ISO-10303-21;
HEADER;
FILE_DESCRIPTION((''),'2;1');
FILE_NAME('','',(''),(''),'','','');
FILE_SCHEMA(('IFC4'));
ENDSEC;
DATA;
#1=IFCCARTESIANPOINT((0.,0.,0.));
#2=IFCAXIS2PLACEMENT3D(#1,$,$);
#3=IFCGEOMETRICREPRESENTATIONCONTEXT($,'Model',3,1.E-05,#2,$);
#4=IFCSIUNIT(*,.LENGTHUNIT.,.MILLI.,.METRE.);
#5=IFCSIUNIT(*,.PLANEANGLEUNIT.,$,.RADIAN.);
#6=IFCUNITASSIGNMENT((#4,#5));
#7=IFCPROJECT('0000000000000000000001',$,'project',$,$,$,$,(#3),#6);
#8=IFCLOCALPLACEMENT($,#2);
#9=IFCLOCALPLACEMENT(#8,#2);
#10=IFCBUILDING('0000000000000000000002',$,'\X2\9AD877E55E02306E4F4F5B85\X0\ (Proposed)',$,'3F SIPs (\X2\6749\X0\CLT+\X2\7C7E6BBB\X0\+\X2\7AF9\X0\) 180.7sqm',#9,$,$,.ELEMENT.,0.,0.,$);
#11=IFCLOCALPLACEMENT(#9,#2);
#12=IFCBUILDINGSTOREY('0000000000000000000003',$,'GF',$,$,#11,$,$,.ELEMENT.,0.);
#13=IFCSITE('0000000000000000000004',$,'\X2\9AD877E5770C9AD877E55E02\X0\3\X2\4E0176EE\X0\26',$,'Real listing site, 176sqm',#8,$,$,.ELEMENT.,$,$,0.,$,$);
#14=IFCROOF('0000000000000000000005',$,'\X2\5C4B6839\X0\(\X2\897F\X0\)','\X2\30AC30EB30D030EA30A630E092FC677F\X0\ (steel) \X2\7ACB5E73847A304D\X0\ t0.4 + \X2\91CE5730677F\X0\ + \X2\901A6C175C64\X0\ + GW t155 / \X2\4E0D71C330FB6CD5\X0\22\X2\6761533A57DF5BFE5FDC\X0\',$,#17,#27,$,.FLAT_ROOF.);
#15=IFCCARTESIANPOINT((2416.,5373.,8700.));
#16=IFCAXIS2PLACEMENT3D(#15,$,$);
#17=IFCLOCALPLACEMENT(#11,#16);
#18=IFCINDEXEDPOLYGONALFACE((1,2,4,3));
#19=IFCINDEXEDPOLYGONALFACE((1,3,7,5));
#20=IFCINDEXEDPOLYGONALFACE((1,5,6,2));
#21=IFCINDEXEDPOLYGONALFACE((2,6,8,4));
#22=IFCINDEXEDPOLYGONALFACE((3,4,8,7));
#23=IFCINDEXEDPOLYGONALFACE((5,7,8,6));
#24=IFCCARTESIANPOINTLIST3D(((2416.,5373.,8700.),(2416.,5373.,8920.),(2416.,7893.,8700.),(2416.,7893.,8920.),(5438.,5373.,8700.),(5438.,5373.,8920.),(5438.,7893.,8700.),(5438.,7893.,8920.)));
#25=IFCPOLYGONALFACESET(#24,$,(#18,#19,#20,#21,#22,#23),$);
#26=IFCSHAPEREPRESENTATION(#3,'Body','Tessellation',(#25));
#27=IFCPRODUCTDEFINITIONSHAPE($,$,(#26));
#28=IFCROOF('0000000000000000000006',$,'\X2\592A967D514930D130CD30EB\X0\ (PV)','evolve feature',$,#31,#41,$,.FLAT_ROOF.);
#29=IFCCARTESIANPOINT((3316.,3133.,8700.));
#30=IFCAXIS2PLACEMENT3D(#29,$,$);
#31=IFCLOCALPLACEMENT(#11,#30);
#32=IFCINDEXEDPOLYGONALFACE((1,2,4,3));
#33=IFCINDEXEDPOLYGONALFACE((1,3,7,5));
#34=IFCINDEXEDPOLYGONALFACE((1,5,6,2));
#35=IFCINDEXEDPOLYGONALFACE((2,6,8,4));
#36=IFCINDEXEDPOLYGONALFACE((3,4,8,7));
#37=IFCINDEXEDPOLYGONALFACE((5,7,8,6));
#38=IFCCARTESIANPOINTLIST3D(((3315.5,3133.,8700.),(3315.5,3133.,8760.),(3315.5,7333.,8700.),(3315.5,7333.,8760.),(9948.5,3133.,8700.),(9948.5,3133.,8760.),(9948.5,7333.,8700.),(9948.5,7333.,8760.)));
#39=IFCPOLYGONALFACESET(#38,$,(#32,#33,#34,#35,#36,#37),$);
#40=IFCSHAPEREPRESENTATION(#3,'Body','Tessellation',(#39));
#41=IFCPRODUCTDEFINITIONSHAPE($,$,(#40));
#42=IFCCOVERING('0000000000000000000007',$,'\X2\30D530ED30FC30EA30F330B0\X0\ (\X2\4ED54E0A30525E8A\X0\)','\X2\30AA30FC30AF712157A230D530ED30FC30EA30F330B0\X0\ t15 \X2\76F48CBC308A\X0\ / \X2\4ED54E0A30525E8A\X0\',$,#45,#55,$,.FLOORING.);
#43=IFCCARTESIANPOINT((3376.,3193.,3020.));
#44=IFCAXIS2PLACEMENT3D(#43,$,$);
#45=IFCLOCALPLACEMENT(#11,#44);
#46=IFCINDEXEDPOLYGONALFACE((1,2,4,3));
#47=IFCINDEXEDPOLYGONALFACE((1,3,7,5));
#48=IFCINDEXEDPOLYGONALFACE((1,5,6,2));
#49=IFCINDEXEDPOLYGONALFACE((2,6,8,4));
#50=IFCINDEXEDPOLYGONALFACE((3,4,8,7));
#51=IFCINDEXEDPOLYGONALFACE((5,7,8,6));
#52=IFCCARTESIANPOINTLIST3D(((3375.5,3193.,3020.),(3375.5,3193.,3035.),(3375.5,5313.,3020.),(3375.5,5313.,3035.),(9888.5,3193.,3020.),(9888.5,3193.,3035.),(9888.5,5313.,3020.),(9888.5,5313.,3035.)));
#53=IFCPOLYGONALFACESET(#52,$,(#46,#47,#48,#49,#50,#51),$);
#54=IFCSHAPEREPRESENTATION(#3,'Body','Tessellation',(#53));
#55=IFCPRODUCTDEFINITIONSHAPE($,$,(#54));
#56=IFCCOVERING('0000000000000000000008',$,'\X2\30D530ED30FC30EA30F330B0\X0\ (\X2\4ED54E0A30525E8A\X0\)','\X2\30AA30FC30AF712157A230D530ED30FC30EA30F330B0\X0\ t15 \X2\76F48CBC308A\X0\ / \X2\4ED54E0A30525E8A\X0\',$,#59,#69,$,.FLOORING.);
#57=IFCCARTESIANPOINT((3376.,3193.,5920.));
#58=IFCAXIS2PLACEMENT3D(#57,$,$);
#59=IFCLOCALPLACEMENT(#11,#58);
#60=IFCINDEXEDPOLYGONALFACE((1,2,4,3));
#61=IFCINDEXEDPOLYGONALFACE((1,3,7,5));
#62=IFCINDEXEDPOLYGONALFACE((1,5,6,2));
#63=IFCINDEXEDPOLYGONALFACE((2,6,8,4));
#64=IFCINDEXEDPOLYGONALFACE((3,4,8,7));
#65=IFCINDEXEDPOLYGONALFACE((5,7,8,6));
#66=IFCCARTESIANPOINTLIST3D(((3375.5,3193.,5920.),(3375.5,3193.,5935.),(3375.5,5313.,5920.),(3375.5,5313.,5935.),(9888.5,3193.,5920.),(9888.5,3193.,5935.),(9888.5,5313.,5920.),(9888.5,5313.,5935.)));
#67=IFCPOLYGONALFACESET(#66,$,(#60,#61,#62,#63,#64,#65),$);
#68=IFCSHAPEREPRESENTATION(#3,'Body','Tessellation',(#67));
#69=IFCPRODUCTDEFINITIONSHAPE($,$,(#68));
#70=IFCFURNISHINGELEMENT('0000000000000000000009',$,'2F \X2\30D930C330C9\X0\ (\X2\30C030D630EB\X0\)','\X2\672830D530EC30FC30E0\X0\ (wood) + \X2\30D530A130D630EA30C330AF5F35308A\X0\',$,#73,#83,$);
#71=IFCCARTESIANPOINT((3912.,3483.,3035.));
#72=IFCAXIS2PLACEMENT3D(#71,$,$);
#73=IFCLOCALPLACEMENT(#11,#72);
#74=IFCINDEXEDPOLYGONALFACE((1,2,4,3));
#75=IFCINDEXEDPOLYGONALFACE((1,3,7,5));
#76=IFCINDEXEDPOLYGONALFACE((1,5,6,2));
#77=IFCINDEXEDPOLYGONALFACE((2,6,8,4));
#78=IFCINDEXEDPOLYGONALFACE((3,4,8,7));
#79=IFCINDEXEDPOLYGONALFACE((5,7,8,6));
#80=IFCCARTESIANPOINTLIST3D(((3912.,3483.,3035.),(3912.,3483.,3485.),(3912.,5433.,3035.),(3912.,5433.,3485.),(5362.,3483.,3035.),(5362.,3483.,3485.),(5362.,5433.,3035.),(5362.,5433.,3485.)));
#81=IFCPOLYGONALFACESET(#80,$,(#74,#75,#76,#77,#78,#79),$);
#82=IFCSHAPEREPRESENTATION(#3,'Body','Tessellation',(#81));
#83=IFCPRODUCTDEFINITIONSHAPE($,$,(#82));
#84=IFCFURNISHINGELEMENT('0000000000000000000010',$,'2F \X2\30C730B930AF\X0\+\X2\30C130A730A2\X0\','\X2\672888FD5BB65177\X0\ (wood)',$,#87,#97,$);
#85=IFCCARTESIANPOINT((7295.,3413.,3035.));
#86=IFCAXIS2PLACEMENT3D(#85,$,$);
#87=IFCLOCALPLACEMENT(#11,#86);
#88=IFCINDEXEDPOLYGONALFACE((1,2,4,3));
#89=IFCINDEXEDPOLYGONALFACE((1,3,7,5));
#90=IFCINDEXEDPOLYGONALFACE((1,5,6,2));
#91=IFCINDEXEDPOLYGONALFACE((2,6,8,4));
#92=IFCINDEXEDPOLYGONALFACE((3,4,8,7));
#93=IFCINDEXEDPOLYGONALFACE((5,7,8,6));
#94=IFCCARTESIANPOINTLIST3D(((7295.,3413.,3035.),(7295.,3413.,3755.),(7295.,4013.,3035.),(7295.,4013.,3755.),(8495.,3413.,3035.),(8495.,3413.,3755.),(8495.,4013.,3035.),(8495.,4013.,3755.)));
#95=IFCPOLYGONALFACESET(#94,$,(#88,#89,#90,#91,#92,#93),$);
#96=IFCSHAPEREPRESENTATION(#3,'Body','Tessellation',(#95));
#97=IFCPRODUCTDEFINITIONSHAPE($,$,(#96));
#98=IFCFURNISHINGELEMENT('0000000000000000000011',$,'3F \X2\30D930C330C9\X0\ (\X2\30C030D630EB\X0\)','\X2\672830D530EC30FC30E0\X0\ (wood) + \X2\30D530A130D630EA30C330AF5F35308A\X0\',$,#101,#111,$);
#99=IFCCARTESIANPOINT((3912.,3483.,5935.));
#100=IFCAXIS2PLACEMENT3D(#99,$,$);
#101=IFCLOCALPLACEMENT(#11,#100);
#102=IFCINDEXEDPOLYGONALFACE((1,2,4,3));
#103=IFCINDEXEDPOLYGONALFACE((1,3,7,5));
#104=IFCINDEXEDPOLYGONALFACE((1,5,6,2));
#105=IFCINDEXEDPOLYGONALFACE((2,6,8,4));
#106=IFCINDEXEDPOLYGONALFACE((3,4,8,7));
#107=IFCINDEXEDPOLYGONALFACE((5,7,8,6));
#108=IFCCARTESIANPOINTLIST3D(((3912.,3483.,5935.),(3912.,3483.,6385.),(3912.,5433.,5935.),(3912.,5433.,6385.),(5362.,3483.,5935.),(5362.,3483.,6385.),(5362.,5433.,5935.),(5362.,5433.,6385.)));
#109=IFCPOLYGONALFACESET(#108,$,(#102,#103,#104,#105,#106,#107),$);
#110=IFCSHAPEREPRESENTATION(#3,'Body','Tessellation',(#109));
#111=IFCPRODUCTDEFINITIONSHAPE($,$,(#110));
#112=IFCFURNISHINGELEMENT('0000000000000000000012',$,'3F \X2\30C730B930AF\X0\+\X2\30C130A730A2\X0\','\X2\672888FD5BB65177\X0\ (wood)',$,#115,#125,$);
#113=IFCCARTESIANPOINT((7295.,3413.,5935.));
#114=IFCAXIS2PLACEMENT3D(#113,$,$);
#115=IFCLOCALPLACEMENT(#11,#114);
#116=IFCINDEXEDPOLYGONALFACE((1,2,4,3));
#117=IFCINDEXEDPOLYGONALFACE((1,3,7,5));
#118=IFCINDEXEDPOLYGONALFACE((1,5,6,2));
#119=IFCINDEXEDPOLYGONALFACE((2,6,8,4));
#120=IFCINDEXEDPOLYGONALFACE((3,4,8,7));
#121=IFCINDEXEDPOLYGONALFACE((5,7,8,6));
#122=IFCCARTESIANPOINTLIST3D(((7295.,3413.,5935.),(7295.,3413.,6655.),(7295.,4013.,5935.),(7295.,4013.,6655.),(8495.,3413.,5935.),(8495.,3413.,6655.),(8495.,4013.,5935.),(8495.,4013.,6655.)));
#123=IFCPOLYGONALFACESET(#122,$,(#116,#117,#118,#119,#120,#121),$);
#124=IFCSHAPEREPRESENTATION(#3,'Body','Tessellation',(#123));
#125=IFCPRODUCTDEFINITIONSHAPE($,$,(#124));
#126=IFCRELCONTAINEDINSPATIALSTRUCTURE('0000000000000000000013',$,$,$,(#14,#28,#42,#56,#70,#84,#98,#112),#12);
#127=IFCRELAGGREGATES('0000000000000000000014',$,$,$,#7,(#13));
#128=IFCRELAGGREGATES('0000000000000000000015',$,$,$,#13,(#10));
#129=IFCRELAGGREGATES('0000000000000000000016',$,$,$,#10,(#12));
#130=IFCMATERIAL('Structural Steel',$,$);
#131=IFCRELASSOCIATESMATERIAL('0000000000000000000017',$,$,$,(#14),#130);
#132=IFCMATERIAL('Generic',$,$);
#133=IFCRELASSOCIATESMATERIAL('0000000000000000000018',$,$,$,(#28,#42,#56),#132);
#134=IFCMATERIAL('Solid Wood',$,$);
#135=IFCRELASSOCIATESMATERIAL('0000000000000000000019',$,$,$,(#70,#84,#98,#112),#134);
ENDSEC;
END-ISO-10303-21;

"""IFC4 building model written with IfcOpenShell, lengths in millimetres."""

from ifc_helpers import new_model, si_unit, frame, frame_2d, origin, place, context, project, spatial, rectangle, extrude, material, element, save


model = new_model("IFC4")

# Units and contexts
model_context = context("Model", 3, precision=1e-05, world=origin())
ifc_project = project(units=[si_unit("LENGTHUNIT", "METRE", prefix="MILLI"), si_unit("PLANEANGLEUNIT", "RADIAN")], contexts=[model_context])

# Site, building, storey
site_placement = place(None, origin())
site = spatial("IfcSite", under=ifc_project, at=site_placement, Name="高知県高知市3丁目26", ObjectType="Real listing site, 176sqm", CompositionType="ELEMENT", RefElevation=0.0)
building_placement = place(site_placement, origin())
building = spatial("IfcBuilding", under=site, at=building_placement, Name="高知市の住宅 (Proposed)", ObjectType="3F SIPs (杉CLT+籾殻+竹) 180.7sqm", CompositionType="ELEMENT", ElevationOfRefHeight=0.0, ElevationOfTerrain=0.0)
storey_placement = place(building_placement, origin())
storey = spatial("IfcBuildingStorey", under=building, at=storey_placement, Name="GF", CompositionType="ELEMENT", Elevation=0.0)

# Shared definitions
ifc_material_1 = material(Name="Solid Wood")

# Roofs
ifc_material_2 = material(Name="Structural Steel")
roof_1_placement = place(storey_placement, frame((2416.0, 5373.0, 8700.0)))
element("IfcRoof", 1, at=roof_1_placement, inside=storey, material=ifc_material_2, Name="屋根(西)", Description="ガルバリウム鋼板 (steel) 立平葺き t0.4 + 野地板 + 通気層 + GW t155 / 不燃・法22条区域対応", PredefinedType="FLAT_ROOF", context=model_context, shape_type="SweptSolid", body=[
    extrude(rectangle(XDim=3022.0, YDim=2520.0, at=frame_2d((1511.0, 1260.0))), frame((2416.0, 5373.0, 8700.0)), (0.0, 0.0, 1.0), 220.0),
])
ifc_material_3 = material(Name="Generic")
roof_2_placement = place(storey_placement, frame((3316.0, 3133.0, 8700.0)))
element("IfcRoof", 2, at=roof_2_placement, inside=storey, material=ifc_material_3, Name="太陽光パネル (PV)", Description="evolve feature", PredefinedType="FLAT_ROOF", context=model_context, shape_type="SweptSolid", body=[
    extrude(rectangle(XDim=6633.0, YDim=4200.0, at=frame_2d((3316.0, 2100.0))), frame((3316.0, 3133.0, 8700.0)), (0.0, 0.0, 1.0), 60.0),
])

# Coverings
covering_1_placement = place(storey_placement, frame((3376.0, 3193.0, 3020.0)))
element("IfcCovering", 3, at=covering_1_placement, inside=storey, material=ifc_material_3, Name="フローリング (仕上げ床)", Description="オーク無垢フローリング t15 直貼り / 仕上げ床", PredefinedType="FLOORING", context=model_context, shape_type="SweptSolid", body=[
    extrude(rectangle(XDim=6513.0, YDim=2120.0, at=frame_2d((3256.0, 1060.0))), frame((3376.0, 3193.0, 3020.0)), (0.0, 0.0, 1.0), 15.0),
])
covering_2_placement = place(storey_placement, frame((3376.0, 3193.0, 5920.0)))
element("IfcCovering", 4, at=covering_2_placement, inside=storey, material=ifc_material_3, Name="フローリング (仕上げ床)", Description="オーク無垢フローリング t15 直貼り / 仕上げ床", PredefinedType="FLOORING", context=model_context, shape_type="SweptSolid", body=[
    extrude(rectangle(XDim=6513.0, YDim=2120.0, at=frame_2d((3256.0, 1060.0))), frame((3376.0, 3193.0, 5920.0)), (0.0, 0.0, 1.0), 15.0),
])

# Furnishing elements
furnishing_1_placement = place(storey_placement, frame((3912.0, 3483.0, 3035.0)))
element("IfcFurnishingElement", 5, at=furnishing_1_placement, inside=storey, material=ifc_material_1, Name="2F ベッド (ダブル)", Description="木フレーム (wood) + ファブリック張り", context=model_context, shape_type="SweptSolid", body=[
    extrude(rectangle(XDim=1450.0, YDim=1950.0, at=frame_2d((725.0, 975.0))), frame((3912.0, 3483.0, 3035.0)), (0.0, 0.0, 1.0), 450.0),
])
furnishing_2_placement = place(storey_placement, frame((7295.0, 3413.0, 3035.0)))
element("IfcFurnishingElement", 6, at=furnishing_2_placement, inside=storey, material=ifc_material_1, Name="2F デスク+チェア", Description="木製家具 (wood)", context=model_context, shape_type="SweptSolid", body=[
    extrude(rectangle(XDim=1200.0, YDim=600.0, at=frame_2d((600.0, 300.0))), frame((7295.0, 3413.0, 3035.0)), (0.0, 0.0, 1.0), 720.0),
])
furnishing_3_placement = place(storey_placement, frame((3912.0, 3483.0, 5935.0)))
element("IfcFurnishingElement", 7, at=furnishing_3_placement, inside=storey, material=ifc_material_1, Name="3F ベッド (ダブル)", Description="木フレーム (wood) + ファブリック張り", context=model_context, shape_type="SweptSolid", body=[
    extrude(rectangle(XDim=1450.0, YDim=1950.0, at=frame_2d((725.0, 975.0))), frame((3912.0, 3483.0, 5935.0)), (0.0, 0.0, 1.0), 450.0),
])
furnishing_4_placement = place(storey_placement, frame((7295.0, 3413.0, 5935.0)))
element("IfcFurnishingElement", 8, at=furnishing_4_placement, inside=storey, material=ifc_material_1, Name="3F デスク+チェア", Description="木製家具 (wood)", context=model_context, shape_type="SweptSolid", body=[
    extrude(rectangle(XDim=1200.0, YDim=600.0, at=frame_2d((600.0, 300.0))), frame((7295.0, 3413.0, 5935.0)), (0.0, 0.0, 1.0), 720.0),
])

save(model, "model.ifc")
